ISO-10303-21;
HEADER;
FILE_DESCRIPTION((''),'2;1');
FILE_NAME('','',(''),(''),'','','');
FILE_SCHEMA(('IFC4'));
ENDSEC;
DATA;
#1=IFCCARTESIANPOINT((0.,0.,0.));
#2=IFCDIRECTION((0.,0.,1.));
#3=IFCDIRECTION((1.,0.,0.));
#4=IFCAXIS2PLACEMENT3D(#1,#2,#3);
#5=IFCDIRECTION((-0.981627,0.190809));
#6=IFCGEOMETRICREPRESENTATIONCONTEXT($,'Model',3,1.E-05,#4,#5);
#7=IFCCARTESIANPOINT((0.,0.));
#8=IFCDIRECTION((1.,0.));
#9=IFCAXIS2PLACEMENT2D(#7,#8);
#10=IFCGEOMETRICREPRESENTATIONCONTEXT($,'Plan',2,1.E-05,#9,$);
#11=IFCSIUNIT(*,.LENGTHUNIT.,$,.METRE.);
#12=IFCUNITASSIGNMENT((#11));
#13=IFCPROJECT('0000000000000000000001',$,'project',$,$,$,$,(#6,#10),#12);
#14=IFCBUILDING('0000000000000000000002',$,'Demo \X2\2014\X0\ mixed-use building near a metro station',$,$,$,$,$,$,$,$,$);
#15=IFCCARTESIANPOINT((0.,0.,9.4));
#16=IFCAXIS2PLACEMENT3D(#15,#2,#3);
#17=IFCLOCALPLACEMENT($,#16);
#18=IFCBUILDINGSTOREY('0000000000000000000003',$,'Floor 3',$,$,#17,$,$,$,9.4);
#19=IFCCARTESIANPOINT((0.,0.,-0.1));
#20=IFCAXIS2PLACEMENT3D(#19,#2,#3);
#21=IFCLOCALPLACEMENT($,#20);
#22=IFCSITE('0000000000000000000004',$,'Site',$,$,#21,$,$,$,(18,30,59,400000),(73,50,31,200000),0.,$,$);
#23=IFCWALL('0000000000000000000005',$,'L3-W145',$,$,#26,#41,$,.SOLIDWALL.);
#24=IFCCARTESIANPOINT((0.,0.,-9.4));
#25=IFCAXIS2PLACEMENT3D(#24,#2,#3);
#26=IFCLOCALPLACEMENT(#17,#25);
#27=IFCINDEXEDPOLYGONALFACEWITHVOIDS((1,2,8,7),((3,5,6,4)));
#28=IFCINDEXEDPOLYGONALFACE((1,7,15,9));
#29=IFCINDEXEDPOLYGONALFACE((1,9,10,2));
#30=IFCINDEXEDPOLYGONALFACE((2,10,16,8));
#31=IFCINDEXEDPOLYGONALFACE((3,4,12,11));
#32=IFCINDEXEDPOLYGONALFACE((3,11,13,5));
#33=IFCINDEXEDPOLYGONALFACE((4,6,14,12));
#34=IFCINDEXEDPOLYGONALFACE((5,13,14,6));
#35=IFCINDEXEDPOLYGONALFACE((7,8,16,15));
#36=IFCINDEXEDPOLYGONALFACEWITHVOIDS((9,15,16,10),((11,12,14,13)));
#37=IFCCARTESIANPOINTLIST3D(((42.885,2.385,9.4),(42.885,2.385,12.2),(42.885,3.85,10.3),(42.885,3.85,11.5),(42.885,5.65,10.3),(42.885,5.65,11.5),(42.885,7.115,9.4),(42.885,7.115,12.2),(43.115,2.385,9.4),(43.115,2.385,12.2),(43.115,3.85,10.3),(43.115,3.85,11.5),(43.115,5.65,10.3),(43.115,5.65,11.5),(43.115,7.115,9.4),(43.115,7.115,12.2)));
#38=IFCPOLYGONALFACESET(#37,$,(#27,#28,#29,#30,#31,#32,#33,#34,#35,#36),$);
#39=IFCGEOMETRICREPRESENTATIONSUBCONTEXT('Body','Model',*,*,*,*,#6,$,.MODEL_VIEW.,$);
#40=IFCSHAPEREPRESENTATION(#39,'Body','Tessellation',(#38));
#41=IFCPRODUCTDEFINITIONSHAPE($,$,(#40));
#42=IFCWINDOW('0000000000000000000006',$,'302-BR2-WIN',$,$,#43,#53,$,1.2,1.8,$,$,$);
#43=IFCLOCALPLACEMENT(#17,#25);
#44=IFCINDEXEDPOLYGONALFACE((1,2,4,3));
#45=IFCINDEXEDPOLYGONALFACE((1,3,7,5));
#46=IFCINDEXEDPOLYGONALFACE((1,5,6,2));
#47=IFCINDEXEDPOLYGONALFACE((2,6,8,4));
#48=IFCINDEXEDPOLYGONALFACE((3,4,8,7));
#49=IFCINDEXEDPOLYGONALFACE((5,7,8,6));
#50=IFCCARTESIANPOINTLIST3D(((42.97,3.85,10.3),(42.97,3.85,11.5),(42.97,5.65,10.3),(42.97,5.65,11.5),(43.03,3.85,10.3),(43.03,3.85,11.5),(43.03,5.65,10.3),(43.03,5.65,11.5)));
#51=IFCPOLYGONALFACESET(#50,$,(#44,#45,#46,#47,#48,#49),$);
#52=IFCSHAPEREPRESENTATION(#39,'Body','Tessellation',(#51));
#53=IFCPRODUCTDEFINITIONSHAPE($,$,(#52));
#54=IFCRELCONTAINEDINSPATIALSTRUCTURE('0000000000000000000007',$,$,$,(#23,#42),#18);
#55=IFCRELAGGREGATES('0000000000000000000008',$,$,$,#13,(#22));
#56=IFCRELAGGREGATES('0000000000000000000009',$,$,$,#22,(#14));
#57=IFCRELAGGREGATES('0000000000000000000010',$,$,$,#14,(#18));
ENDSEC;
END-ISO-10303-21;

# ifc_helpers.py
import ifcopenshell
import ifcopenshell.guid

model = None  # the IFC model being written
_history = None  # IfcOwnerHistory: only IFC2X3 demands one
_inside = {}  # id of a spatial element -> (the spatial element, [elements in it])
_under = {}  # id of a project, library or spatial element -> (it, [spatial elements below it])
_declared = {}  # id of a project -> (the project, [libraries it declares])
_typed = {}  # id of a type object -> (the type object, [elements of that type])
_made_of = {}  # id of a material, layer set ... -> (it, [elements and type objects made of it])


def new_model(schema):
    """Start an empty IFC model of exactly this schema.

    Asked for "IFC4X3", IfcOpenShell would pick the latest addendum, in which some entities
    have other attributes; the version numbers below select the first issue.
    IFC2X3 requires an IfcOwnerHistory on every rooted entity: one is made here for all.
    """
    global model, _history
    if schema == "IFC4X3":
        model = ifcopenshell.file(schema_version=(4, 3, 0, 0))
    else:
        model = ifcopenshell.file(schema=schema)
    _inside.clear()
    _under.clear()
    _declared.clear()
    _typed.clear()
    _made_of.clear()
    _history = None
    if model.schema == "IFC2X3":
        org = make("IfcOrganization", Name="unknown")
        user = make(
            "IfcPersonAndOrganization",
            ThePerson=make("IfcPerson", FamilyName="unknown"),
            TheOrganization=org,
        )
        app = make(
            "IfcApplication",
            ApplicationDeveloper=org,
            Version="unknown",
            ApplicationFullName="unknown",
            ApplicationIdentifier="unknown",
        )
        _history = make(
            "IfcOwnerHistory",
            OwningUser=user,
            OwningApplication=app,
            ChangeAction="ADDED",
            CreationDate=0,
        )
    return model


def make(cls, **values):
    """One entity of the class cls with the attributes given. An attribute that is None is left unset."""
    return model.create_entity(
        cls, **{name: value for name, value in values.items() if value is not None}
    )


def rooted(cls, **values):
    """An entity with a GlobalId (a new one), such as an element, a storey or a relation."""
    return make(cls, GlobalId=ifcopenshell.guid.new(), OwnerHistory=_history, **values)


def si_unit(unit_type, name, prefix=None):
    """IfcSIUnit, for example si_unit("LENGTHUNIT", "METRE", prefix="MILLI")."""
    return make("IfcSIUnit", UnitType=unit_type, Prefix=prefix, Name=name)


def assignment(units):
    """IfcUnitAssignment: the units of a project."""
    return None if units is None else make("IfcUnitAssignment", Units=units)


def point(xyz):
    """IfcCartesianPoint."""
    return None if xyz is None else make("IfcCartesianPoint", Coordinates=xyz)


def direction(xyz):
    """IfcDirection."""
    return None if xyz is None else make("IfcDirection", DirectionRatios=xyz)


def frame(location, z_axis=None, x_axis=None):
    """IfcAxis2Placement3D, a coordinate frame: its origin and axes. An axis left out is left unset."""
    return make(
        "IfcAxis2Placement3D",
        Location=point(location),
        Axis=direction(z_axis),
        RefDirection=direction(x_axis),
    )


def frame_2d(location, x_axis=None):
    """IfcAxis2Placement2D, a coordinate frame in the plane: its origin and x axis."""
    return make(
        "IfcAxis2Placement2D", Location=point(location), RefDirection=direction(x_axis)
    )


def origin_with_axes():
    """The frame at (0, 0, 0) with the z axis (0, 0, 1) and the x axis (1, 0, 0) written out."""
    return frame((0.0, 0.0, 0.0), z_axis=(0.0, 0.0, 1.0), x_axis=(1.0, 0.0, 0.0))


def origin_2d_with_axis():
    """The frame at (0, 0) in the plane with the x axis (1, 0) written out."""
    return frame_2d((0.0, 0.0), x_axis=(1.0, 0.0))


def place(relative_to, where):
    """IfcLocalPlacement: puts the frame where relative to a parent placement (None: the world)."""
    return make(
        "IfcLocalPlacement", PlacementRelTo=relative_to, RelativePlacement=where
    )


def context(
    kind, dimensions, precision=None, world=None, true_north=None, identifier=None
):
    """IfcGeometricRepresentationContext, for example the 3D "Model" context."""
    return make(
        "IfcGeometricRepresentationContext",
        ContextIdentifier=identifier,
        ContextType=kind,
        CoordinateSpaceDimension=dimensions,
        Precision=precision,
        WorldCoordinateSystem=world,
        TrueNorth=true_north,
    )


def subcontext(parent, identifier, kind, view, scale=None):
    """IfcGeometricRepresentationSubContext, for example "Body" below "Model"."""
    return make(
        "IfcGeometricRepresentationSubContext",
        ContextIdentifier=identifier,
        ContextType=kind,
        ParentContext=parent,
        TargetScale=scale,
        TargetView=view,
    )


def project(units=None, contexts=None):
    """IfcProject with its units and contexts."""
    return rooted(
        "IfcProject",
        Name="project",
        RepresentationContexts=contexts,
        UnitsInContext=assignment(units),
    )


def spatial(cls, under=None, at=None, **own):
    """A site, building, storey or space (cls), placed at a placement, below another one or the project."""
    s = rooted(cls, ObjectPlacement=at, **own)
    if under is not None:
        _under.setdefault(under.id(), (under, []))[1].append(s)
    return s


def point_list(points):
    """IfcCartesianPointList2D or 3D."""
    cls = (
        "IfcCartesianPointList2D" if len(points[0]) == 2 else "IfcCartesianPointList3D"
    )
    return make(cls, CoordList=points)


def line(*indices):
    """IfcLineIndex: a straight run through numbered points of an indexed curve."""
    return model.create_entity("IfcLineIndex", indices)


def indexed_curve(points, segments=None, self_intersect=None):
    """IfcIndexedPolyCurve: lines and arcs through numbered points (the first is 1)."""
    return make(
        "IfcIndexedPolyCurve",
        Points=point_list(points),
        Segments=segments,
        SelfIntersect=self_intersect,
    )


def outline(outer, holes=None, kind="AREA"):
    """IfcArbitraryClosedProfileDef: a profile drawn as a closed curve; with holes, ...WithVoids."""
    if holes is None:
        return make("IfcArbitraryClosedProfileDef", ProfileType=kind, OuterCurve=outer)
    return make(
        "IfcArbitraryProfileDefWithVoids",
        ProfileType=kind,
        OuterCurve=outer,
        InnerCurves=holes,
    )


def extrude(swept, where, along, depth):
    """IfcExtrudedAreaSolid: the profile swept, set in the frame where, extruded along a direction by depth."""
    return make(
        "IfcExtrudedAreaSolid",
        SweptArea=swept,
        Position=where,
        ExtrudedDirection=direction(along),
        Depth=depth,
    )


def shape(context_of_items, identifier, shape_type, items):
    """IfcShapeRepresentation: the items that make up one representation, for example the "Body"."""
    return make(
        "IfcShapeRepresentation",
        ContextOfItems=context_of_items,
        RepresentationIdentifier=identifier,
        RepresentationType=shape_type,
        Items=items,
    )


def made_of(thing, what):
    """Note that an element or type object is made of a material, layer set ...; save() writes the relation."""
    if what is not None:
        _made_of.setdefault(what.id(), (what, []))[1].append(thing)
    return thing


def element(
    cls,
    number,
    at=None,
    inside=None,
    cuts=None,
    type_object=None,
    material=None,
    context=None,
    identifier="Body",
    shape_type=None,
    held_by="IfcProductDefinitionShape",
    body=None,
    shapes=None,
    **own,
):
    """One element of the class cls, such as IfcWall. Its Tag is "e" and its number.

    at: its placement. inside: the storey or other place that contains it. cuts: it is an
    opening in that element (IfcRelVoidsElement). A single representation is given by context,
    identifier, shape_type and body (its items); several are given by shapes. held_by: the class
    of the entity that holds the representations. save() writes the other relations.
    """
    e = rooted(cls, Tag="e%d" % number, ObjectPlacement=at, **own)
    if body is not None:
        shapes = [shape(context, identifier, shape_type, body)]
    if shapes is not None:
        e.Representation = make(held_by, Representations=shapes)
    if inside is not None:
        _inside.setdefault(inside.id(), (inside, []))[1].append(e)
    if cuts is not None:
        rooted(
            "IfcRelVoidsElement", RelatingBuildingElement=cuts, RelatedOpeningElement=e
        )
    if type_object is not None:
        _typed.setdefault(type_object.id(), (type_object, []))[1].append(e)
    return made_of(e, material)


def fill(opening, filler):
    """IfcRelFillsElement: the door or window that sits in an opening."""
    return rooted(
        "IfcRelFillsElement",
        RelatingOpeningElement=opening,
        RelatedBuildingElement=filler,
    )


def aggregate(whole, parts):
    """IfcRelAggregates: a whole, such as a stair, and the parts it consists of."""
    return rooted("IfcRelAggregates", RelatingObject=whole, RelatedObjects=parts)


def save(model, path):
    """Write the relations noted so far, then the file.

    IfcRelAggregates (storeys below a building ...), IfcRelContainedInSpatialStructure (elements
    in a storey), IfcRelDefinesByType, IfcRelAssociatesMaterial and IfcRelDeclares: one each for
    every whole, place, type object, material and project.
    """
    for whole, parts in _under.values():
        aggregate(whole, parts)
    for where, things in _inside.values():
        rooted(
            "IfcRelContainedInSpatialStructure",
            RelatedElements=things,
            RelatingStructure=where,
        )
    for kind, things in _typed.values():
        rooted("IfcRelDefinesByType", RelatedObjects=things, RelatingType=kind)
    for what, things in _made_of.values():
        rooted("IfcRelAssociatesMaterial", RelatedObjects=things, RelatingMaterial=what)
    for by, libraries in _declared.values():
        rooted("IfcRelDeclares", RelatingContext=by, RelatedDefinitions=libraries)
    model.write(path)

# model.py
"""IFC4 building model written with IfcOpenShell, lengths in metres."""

from ifc_helpers import new_model, si_unit, direction, frame, origin_with_axes, origin_2d_with_axis, place, context, subcontext, project, spatial, line, indexed_curve, outline, extrude, element, fill, save


model = new_model("IFC4")

# Units and contexts
model_context = context("Model", 3, precision=1e-05, world=origin_with_axes(), true_north=direction((-0.981627, 0.190809)))
plan_context = context("Plan", 2, precision=1e-05, world=origin_2d_with_axis())
body_context = subcontext(model_context, "Body", "Model", "MODEL_VIEW")
ifc_project = project(units=[si_unit("LENGTHUNIT", "METRE")], contexts=[model_context, plan_context])

# Site, building, storey
site_placement = place(None, frame((0.0, 0.0, -0.1), z_axis=(0.0, 0.0, 1.0), x_axis=(1.0, 0.0, 0.0)))
site = spatial("IfcSite", under=ifc_project, at=site_placement, Name="Site", RefLatitude=(18, 30, 59, 400000), RefLongitude=(73, 50, 31, 200000), RefElevation=0.0)
building = spatial("IfcBuilding", under=site, Name="Demo — mixed-use building near a metro station")
storey_placement = place(None, frame((0.0, 0.0, 9.4), z_axis=(0.0, 0.0, 1.0), x_axis=(1.0, 0.0, 0.0)))
storey = spatial("IfcBuildingStorey", under=building, at=storey_placement, Name="Floor 3", Elevation=9.4)

# Wall, opening, window
wall_1_placement = place(storey_placement, frame((0.0, 0.0, -9.4), z_axis=(0.0, 0.0, 1.0), x_axis=(1.0, 0.0, 0.0)))
wall_1 = element("IfcWall", 1, at=wall_1_placement, inside=storey, Name="L3-W145", PredefinedType="SOLIDWALL", context=body_context, shape_type="SweptSolid", body=[
    extrude(outline(indexed_curve([(42.885, 2.385), (42.885, 7.115), (43.115, 7.115), (43.115, 2.385)], segments=[line(1, 2, 3, 4, 1)])), frame((0.0, 0.0, 9.4), z_axis=(0.0, 0.0, 1.0), x_axis=(1.0, 0.0, 0.0)), (0.0, 0.0, 1.0), 2.8),
])
opening_1_placement = place(wall_1_placement, origin_with_axes())
opening_1 = element("IfcOpeningElement", 2, at=opening_1_placement, cuts=wall_1, context=body_context, shape_type="SweptSolid", body=[
    extrude(outline(indexed_curve([(42.835, 3.85), (42.835, 5.65), (43.165, 5.65), (43.165, 3.85)], segments=[line(1, 2, 3, 4, 1)])), frame((0.0, 0.0, 10.3), z_axis=(0.0, 0.0, 1.0), x_axis=(1.0, 0.0, 0.0)), (0.0, 0.0, 1.0), 1.2),
])
window_1_placement = place(storey_placement, frame((0.0, 0.0, -9.4), z_axis=(0.0, 0.0, 1.0), x_axis=(1.0, 0.0, 0.0)))
window_1 = element("IfcWindow", 3, at=window_1_placement, inside=storey, Name="302-BR2-WIN", OverallHeight=1.2, OverallWidth=1.8, context=body_context, shape_type="SweptSolid", body=[
    extrude(outline(indexed_curve([(42.97, 3.85), (42.97, 5.65), (43.03, 5.65), (43.03, 3.85)], segments=[line(1, 2, 3, 4, 1)])), frame((0.0, 0.0, 10.3), z_axis=(0.0, 0.0, 1.0), x_axis=(1.0, 0.0, 0.0)), (0.0, 0.0, 1.0), 1.2),
])
fill(opening_1, window_1)

save(model, "model.ifc")
